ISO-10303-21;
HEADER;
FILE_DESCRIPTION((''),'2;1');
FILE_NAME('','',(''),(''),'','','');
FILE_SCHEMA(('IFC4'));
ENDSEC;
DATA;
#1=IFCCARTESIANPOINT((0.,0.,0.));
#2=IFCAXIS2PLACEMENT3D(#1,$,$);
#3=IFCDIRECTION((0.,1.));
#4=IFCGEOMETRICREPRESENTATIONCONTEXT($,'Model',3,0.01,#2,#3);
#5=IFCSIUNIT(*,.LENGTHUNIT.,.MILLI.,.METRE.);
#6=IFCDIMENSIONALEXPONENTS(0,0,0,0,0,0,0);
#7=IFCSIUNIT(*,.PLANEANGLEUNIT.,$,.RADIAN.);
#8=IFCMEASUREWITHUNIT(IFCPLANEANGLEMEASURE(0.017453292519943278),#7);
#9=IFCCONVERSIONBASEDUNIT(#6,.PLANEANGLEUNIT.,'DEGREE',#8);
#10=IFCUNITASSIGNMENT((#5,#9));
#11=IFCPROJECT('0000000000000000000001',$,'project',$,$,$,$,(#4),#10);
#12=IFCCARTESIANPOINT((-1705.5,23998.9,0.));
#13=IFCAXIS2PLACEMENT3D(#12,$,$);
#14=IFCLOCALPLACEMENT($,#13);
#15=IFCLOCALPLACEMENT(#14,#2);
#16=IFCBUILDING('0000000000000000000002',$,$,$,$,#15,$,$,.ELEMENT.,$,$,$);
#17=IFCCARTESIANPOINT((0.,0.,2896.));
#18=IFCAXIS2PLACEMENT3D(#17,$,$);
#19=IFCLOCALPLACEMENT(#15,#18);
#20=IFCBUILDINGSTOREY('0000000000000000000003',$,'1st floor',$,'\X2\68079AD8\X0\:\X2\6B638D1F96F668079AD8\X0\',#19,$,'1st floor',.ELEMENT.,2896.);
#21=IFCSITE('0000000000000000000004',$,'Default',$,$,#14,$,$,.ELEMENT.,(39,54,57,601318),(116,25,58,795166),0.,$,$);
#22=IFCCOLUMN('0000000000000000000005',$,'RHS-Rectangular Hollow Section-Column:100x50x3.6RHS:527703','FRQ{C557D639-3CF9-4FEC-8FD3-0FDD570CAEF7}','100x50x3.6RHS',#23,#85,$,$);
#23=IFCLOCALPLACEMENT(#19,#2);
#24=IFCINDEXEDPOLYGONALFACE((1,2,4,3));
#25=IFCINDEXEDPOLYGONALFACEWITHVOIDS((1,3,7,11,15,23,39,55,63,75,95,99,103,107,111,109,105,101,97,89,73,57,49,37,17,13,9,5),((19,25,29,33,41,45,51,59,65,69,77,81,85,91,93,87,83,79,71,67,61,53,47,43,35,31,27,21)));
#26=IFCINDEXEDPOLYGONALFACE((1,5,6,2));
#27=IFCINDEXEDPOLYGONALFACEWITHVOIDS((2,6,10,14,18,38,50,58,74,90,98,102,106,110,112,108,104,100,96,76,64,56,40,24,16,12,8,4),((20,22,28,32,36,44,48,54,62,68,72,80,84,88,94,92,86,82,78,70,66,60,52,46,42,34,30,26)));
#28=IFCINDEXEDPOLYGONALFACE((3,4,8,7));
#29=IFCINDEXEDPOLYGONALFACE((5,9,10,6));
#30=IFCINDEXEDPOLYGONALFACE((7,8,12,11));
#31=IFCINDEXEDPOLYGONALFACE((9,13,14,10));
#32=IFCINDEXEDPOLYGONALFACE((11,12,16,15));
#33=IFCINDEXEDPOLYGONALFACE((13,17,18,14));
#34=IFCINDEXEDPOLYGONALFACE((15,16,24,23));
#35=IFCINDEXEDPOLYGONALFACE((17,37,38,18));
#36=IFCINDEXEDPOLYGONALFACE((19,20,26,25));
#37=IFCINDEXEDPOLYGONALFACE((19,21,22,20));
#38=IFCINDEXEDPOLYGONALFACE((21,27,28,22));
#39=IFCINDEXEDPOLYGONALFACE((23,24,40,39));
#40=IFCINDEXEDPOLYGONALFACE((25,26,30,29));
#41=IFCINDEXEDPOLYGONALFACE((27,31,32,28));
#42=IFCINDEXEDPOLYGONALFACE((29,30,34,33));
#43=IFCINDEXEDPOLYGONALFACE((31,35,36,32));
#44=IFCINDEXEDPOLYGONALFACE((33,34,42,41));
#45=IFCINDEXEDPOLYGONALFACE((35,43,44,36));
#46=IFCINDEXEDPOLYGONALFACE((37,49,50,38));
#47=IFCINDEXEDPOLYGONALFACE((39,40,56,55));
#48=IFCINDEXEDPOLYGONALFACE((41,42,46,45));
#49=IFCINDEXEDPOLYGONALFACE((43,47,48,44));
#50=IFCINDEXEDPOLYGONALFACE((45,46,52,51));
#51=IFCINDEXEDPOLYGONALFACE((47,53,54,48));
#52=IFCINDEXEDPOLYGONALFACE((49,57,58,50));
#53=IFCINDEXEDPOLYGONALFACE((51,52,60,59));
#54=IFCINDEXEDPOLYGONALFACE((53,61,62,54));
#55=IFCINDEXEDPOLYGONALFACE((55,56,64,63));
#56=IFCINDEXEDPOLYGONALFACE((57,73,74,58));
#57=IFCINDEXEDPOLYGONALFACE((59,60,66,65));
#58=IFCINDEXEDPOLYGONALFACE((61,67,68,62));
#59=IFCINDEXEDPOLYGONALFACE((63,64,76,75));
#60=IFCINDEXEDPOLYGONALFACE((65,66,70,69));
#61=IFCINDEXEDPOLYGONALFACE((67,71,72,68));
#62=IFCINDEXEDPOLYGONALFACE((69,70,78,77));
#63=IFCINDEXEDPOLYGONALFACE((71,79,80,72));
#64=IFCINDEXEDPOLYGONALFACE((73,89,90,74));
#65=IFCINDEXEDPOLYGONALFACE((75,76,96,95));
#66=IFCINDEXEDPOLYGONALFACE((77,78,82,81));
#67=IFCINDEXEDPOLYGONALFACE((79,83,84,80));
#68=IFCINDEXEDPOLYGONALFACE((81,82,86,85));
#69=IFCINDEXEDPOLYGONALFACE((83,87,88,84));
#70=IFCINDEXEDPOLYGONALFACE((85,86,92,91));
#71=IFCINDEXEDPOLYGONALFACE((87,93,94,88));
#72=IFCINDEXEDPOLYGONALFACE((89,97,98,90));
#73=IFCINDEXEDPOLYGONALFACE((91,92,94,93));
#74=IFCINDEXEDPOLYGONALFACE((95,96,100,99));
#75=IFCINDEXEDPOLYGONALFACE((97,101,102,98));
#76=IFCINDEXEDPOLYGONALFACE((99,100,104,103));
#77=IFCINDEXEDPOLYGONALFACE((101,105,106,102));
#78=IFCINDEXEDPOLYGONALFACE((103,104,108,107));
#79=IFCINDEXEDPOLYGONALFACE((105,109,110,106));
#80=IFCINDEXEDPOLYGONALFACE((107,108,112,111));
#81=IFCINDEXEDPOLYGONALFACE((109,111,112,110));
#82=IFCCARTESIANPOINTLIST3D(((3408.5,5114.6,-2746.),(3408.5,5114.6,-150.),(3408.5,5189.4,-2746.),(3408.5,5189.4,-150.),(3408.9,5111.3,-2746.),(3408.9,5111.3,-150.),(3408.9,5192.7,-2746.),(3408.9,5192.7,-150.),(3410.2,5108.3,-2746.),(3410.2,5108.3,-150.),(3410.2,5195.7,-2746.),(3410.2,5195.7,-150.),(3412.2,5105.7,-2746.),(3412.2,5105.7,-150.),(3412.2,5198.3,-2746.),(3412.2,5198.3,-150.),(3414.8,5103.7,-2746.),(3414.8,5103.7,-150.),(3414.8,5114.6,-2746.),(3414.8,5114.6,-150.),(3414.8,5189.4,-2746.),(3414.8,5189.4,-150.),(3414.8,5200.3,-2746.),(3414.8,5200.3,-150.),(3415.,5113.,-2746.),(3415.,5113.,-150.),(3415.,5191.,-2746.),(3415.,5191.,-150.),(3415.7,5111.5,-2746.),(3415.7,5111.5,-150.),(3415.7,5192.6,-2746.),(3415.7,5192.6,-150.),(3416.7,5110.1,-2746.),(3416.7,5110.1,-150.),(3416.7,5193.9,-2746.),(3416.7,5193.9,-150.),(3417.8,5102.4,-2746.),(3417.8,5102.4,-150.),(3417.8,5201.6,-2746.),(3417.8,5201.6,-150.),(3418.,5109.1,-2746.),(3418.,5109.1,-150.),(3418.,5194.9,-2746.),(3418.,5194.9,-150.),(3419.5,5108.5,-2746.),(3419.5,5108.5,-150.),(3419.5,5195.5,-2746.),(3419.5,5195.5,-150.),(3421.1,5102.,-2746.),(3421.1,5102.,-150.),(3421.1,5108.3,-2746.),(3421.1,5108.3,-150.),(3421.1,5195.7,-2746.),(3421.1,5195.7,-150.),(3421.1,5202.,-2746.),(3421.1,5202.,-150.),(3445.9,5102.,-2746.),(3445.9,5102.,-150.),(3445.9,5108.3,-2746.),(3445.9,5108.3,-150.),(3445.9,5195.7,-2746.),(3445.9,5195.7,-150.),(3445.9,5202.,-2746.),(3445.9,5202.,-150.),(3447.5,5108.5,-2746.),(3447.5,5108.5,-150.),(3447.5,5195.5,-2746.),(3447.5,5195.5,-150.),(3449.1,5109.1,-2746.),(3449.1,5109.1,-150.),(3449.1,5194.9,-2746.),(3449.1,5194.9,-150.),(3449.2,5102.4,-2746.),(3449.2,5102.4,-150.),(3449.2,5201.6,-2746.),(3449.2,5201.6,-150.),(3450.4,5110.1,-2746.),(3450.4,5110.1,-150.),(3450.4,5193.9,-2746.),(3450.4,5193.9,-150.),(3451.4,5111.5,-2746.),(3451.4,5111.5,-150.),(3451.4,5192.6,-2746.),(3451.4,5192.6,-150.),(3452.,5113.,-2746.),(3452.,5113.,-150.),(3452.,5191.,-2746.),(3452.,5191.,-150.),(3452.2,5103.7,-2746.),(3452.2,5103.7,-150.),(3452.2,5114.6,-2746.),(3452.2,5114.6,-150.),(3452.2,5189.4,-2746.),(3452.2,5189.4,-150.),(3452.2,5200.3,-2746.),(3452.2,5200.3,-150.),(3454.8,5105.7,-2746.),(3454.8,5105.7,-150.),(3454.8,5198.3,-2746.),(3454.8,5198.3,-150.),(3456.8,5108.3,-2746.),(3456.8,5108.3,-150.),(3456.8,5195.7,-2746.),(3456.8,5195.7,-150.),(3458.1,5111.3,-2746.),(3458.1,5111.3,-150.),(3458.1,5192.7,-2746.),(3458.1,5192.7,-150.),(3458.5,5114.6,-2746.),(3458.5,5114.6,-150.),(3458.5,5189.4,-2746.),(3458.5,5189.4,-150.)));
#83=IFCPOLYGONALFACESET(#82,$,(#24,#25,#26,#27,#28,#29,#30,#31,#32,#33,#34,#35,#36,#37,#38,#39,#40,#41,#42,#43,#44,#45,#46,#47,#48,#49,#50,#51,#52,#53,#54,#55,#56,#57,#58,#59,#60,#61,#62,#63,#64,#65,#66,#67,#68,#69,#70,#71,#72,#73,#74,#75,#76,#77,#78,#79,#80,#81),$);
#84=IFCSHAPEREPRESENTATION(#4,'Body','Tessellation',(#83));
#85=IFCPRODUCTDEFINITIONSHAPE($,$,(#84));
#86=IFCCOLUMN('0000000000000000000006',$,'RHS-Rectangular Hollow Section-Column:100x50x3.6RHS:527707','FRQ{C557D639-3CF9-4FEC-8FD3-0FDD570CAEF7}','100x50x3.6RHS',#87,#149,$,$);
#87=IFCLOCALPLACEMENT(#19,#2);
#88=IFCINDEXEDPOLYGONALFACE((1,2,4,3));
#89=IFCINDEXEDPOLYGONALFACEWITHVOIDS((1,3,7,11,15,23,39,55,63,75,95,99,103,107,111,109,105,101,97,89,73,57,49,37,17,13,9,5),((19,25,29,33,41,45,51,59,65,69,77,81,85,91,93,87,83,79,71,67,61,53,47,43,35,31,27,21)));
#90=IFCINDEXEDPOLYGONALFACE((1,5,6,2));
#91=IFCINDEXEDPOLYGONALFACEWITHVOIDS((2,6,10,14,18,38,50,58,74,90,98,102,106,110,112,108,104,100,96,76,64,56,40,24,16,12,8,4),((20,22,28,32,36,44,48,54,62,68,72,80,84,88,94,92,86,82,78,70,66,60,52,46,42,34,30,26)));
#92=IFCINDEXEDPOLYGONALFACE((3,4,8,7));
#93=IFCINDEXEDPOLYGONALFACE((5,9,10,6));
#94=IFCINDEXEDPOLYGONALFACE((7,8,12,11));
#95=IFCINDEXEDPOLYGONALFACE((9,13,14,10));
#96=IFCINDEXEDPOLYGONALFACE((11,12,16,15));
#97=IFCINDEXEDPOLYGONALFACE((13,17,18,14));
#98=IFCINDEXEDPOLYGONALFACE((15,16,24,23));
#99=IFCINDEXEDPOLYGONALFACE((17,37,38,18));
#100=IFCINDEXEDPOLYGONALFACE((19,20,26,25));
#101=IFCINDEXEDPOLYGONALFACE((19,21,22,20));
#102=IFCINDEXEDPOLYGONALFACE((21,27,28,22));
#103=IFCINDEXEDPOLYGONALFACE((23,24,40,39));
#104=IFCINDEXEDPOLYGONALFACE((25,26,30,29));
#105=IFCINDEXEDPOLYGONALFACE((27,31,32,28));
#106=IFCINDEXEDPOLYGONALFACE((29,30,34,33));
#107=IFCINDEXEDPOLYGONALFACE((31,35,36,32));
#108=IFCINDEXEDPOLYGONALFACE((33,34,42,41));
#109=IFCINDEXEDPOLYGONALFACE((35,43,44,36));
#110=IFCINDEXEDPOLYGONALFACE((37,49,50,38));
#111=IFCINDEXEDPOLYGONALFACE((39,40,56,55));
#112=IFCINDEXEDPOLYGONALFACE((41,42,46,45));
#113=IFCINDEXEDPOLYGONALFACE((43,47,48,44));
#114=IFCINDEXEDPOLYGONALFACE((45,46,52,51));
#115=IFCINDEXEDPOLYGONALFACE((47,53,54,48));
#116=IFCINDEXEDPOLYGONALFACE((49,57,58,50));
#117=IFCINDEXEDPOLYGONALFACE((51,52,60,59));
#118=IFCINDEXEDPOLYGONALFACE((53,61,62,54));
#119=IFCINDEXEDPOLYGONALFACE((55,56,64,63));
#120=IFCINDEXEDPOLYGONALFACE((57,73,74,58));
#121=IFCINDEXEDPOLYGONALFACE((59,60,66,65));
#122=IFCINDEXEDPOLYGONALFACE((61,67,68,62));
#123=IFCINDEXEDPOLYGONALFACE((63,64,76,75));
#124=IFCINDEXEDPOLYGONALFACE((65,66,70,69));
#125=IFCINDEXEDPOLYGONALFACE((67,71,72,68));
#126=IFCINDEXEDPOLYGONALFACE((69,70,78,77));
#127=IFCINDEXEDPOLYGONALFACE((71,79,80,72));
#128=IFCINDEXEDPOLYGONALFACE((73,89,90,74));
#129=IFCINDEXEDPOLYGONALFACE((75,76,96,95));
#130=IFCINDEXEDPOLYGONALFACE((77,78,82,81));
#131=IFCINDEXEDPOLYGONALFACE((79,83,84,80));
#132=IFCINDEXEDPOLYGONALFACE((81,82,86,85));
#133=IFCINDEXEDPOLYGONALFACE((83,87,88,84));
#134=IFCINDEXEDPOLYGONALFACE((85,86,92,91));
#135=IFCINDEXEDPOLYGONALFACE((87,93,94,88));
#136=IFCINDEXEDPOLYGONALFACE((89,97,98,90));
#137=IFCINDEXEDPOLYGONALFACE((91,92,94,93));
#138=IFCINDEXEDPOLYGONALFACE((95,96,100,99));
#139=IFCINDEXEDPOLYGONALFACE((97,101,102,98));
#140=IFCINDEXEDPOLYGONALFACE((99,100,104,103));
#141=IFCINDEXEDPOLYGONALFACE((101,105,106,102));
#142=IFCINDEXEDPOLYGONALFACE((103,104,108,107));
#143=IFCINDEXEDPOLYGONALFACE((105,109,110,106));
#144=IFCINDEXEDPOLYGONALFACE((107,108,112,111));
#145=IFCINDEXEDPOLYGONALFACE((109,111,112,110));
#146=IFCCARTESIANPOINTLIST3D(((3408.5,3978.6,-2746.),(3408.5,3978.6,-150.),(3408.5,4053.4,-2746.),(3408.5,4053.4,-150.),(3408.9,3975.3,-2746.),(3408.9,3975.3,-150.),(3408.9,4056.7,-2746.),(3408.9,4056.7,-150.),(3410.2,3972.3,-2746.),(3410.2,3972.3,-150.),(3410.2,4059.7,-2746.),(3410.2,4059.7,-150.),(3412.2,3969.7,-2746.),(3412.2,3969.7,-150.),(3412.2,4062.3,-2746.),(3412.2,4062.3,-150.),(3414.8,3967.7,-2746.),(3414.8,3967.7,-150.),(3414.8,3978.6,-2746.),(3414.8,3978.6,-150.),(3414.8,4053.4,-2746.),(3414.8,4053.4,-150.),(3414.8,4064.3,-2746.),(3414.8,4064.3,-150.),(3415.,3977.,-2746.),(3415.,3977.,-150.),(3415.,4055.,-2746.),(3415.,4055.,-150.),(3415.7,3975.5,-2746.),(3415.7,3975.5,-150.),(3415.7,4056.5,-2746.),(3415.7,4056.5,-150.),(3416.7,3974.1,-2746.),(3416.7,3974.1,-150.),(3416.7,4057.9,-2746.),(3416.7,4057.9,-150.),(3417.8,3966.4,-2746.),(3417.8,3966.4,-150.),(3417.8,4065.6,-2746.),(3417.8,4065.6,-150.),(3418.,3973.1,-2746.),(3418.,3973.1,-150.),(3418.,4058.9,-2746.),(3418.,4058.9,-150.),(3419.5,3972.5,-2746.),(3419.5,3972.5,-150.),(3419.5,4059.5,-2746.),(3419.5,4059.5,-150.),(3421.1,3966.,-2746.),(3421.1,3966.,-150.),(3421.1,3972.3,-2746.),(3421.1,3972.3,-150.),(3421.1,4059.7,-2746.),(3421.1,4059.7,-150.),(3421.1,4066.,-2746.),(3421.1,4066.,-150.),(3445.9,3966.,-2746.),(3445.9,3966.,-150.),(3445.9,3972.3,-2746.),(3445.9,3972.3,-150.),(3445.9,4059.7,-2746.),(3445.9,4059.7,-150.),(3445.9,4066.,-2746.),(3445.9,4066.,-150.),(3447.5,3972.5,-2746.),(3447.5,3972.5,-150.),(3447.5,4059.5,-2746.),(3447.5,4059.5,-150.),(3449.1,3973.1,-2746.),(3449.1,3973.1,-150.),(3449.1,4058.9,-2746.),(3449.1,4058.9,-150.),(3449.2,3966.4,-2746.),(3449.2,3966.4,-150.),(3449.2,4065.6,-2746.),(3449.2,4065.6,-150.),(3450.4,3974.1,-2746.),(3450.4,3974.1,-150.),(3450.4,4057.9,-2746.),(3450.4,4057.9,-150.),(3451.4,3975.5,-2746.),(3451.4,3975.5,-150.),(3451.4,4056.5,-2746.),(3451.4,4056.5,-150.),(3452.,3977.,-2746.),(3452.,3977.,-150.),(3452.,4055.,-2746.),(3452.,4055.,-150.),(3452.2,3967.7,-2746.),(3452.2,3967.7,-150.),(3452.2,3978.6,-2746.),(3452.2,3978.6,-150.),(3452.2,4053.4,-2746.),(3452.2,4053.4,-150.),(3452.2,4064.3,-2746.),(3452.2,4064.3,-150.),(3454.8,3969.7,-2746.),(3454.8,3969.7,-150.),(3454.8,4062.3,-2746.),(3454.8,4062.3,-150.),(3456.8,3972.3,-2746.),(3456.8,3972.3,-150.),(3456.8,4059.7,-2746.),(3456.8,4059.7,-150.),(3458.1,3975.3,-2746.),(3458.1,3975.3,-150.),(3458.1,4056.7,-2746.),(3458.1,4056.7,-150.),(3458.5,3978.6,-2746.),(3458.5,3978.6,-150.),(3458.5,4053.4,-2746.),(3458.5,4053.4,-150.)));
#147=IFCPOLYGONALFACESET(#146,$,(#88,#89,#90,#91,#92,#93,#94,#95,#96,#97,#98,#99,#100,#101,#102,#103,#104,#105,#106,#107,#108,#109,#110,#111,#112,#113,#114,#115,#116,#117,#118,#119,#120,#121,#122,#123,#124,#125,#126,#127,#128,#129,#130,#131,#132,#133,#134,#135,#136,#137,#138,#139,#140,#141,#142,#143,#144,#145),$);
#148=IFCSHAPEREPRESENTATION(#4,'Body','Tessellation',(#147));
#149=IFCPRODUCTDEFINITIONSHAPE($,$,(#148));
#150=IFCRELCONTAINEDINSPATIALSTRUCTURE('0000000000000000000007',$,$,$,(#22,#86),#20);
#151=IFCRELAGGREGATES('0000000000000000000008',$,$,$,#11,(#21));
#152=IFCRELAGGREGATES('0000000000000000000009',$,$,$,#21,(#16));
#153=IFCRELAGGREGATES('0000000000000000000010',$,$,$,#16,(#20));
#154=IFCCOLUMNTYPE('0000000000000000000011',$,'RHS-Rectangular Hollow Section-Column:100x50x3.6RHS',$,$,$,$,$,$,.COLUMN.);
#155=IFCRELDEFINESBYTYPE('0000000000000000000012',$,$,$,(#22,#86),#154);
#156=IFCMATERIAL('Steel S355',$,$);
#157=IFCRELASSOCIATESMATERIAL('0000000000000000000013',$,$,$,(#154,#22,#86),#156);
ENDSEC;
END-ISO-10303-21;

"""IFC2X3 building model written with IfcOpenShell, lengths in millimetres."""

from ifc_helpers import new_model, entity, si_unit, converted_unit, direction, frame, origin, origin_2d, place, context, project, spatial, hollow_rectangle, extrude, clip, halfspace, material, type_object, element, save


model = new_model("IFC2X3")

# Units and contexts
model_context = context("Model", 3, precision=0.01, world=origin(), true_north=direction((0.0, 1.0)))
ifc_project = project(units=[si_unit("LENGTHUNIT", "METRE", prefix="MILLI"), converted_unit("PLANEANGLEUNIT", "DEGREE", entity("IfcPlaneAngleMeasure", 0.017453292519943278), si_unit("PLANEANGLEUNIT", "RADIAN"), dimensions=[0, 0, 0, 0, 0, 0, 0])], contexts=[model_context])

# Site, building, storey
site_placement = place(None, frame((-1705.5, 23998.9, 0.0)))
site = spatial("IfcSite", under=ifc_project, at=site_placement, Name="Default", CompositionType="ELEMENT", RefLatitude=(39, 54, 57, 601318), RefLongitude=(116, 25, 58, 795166), RefElevation=0.0)
building_placement = place(site_placement, origin())
building = spatial("IfcBuilding", under=site, at=building_placement, CompositionType="ELEMENT")
storey_placement = place(building_placement, frame((0.0, 0.0, 2896.0)))
storey = spatial("IfcBuildingStorey", under=building, at=storey_placement, Name="1st floor", ObjectType="标高:正负零标高", LongName="1st floor", CompositionType="ELEMENT", Elevation=2896.0)

# Columns
ifc_material_1 = material(Name="Steel S355")
column_type_1 = type_object("IfcColumnType", Name="RHS-Rectangular Hollow Section-Column:100x50x3.6RHS", PredefinedType="COLUMN", material=ifc_material_1)
column_1_placement = place(storey_placement, frame((3433.5, 5152.0, -150.0), z_axis=(0.0, 0.0, 1.0), x_axis=(-1.0, 0.0, 0.0)))
element("IfcColumn", 1, at=column_1_placement, inside=storey, type_object=column_type_1, material=ifc_material_1, Name="RHS-Rectangular Hollow Section-Column:100x50x3.6RHS:527703", Description="FRQ{C557D639-3CF9-4FEC-8FD3-0FDD570CAEF7}", ObjectType="100x50x3.6RHS", context=model_context, shape_type="Clipping", body=[
    clip(extrude(hollow_rectangle(XDim=50.0, YDim=100.0, WallThickness=6.3, InnerFilletRadius=6.3, OuterFilletRadius=12.6, at=origin_2d()), origin(), (0.0, 0.0, -1.0), 2651.9), halfspace(frame((3433.5, 5152.0, -2596.0), z_axis=(0.0, 0.0, 1.0), x_axis=(-1.0, 0.0, 0.0)), True)),
])
column_2_placement = place(storey_placement, frame((3433.5, 4016.0, -150.0), z_axis=(0.0, 0.0, 1.0), x_axis=(-1.0, 0.0, 0.0)))
element("IfcColumn", 2, at=column_2_placement, inside=storey, type_object=column_type_1, material=ifc_material_1, Name="RHS-Rectangular Hollow Section-Column:100x50x3.6RHS:527707", Description="FRQ{C557D639-3CF9-4FEC-8FD3-0FDD570CAEF7}", ObjectType="100x50x3.6RHS", context=model_context, shape_type="Clipping", body=[
    clip(extrude(hollow_rectangle(XDim=50.0, YDim=100.0, WallThickness=6.3, InnerFilletRadius=6.3, OuterFilletRadius=12.6, at=origin_2d()), origin(), (0.0, 0.0, -1.0), 2651.9), halfspace(frame((3433.5, 4016.0, -2596.0), z_axis=(0.0, 0.0, 1.0), x_axis=(-1.0, 0.0, 0.0)), True)),
])

save(model, "model.ifc")
